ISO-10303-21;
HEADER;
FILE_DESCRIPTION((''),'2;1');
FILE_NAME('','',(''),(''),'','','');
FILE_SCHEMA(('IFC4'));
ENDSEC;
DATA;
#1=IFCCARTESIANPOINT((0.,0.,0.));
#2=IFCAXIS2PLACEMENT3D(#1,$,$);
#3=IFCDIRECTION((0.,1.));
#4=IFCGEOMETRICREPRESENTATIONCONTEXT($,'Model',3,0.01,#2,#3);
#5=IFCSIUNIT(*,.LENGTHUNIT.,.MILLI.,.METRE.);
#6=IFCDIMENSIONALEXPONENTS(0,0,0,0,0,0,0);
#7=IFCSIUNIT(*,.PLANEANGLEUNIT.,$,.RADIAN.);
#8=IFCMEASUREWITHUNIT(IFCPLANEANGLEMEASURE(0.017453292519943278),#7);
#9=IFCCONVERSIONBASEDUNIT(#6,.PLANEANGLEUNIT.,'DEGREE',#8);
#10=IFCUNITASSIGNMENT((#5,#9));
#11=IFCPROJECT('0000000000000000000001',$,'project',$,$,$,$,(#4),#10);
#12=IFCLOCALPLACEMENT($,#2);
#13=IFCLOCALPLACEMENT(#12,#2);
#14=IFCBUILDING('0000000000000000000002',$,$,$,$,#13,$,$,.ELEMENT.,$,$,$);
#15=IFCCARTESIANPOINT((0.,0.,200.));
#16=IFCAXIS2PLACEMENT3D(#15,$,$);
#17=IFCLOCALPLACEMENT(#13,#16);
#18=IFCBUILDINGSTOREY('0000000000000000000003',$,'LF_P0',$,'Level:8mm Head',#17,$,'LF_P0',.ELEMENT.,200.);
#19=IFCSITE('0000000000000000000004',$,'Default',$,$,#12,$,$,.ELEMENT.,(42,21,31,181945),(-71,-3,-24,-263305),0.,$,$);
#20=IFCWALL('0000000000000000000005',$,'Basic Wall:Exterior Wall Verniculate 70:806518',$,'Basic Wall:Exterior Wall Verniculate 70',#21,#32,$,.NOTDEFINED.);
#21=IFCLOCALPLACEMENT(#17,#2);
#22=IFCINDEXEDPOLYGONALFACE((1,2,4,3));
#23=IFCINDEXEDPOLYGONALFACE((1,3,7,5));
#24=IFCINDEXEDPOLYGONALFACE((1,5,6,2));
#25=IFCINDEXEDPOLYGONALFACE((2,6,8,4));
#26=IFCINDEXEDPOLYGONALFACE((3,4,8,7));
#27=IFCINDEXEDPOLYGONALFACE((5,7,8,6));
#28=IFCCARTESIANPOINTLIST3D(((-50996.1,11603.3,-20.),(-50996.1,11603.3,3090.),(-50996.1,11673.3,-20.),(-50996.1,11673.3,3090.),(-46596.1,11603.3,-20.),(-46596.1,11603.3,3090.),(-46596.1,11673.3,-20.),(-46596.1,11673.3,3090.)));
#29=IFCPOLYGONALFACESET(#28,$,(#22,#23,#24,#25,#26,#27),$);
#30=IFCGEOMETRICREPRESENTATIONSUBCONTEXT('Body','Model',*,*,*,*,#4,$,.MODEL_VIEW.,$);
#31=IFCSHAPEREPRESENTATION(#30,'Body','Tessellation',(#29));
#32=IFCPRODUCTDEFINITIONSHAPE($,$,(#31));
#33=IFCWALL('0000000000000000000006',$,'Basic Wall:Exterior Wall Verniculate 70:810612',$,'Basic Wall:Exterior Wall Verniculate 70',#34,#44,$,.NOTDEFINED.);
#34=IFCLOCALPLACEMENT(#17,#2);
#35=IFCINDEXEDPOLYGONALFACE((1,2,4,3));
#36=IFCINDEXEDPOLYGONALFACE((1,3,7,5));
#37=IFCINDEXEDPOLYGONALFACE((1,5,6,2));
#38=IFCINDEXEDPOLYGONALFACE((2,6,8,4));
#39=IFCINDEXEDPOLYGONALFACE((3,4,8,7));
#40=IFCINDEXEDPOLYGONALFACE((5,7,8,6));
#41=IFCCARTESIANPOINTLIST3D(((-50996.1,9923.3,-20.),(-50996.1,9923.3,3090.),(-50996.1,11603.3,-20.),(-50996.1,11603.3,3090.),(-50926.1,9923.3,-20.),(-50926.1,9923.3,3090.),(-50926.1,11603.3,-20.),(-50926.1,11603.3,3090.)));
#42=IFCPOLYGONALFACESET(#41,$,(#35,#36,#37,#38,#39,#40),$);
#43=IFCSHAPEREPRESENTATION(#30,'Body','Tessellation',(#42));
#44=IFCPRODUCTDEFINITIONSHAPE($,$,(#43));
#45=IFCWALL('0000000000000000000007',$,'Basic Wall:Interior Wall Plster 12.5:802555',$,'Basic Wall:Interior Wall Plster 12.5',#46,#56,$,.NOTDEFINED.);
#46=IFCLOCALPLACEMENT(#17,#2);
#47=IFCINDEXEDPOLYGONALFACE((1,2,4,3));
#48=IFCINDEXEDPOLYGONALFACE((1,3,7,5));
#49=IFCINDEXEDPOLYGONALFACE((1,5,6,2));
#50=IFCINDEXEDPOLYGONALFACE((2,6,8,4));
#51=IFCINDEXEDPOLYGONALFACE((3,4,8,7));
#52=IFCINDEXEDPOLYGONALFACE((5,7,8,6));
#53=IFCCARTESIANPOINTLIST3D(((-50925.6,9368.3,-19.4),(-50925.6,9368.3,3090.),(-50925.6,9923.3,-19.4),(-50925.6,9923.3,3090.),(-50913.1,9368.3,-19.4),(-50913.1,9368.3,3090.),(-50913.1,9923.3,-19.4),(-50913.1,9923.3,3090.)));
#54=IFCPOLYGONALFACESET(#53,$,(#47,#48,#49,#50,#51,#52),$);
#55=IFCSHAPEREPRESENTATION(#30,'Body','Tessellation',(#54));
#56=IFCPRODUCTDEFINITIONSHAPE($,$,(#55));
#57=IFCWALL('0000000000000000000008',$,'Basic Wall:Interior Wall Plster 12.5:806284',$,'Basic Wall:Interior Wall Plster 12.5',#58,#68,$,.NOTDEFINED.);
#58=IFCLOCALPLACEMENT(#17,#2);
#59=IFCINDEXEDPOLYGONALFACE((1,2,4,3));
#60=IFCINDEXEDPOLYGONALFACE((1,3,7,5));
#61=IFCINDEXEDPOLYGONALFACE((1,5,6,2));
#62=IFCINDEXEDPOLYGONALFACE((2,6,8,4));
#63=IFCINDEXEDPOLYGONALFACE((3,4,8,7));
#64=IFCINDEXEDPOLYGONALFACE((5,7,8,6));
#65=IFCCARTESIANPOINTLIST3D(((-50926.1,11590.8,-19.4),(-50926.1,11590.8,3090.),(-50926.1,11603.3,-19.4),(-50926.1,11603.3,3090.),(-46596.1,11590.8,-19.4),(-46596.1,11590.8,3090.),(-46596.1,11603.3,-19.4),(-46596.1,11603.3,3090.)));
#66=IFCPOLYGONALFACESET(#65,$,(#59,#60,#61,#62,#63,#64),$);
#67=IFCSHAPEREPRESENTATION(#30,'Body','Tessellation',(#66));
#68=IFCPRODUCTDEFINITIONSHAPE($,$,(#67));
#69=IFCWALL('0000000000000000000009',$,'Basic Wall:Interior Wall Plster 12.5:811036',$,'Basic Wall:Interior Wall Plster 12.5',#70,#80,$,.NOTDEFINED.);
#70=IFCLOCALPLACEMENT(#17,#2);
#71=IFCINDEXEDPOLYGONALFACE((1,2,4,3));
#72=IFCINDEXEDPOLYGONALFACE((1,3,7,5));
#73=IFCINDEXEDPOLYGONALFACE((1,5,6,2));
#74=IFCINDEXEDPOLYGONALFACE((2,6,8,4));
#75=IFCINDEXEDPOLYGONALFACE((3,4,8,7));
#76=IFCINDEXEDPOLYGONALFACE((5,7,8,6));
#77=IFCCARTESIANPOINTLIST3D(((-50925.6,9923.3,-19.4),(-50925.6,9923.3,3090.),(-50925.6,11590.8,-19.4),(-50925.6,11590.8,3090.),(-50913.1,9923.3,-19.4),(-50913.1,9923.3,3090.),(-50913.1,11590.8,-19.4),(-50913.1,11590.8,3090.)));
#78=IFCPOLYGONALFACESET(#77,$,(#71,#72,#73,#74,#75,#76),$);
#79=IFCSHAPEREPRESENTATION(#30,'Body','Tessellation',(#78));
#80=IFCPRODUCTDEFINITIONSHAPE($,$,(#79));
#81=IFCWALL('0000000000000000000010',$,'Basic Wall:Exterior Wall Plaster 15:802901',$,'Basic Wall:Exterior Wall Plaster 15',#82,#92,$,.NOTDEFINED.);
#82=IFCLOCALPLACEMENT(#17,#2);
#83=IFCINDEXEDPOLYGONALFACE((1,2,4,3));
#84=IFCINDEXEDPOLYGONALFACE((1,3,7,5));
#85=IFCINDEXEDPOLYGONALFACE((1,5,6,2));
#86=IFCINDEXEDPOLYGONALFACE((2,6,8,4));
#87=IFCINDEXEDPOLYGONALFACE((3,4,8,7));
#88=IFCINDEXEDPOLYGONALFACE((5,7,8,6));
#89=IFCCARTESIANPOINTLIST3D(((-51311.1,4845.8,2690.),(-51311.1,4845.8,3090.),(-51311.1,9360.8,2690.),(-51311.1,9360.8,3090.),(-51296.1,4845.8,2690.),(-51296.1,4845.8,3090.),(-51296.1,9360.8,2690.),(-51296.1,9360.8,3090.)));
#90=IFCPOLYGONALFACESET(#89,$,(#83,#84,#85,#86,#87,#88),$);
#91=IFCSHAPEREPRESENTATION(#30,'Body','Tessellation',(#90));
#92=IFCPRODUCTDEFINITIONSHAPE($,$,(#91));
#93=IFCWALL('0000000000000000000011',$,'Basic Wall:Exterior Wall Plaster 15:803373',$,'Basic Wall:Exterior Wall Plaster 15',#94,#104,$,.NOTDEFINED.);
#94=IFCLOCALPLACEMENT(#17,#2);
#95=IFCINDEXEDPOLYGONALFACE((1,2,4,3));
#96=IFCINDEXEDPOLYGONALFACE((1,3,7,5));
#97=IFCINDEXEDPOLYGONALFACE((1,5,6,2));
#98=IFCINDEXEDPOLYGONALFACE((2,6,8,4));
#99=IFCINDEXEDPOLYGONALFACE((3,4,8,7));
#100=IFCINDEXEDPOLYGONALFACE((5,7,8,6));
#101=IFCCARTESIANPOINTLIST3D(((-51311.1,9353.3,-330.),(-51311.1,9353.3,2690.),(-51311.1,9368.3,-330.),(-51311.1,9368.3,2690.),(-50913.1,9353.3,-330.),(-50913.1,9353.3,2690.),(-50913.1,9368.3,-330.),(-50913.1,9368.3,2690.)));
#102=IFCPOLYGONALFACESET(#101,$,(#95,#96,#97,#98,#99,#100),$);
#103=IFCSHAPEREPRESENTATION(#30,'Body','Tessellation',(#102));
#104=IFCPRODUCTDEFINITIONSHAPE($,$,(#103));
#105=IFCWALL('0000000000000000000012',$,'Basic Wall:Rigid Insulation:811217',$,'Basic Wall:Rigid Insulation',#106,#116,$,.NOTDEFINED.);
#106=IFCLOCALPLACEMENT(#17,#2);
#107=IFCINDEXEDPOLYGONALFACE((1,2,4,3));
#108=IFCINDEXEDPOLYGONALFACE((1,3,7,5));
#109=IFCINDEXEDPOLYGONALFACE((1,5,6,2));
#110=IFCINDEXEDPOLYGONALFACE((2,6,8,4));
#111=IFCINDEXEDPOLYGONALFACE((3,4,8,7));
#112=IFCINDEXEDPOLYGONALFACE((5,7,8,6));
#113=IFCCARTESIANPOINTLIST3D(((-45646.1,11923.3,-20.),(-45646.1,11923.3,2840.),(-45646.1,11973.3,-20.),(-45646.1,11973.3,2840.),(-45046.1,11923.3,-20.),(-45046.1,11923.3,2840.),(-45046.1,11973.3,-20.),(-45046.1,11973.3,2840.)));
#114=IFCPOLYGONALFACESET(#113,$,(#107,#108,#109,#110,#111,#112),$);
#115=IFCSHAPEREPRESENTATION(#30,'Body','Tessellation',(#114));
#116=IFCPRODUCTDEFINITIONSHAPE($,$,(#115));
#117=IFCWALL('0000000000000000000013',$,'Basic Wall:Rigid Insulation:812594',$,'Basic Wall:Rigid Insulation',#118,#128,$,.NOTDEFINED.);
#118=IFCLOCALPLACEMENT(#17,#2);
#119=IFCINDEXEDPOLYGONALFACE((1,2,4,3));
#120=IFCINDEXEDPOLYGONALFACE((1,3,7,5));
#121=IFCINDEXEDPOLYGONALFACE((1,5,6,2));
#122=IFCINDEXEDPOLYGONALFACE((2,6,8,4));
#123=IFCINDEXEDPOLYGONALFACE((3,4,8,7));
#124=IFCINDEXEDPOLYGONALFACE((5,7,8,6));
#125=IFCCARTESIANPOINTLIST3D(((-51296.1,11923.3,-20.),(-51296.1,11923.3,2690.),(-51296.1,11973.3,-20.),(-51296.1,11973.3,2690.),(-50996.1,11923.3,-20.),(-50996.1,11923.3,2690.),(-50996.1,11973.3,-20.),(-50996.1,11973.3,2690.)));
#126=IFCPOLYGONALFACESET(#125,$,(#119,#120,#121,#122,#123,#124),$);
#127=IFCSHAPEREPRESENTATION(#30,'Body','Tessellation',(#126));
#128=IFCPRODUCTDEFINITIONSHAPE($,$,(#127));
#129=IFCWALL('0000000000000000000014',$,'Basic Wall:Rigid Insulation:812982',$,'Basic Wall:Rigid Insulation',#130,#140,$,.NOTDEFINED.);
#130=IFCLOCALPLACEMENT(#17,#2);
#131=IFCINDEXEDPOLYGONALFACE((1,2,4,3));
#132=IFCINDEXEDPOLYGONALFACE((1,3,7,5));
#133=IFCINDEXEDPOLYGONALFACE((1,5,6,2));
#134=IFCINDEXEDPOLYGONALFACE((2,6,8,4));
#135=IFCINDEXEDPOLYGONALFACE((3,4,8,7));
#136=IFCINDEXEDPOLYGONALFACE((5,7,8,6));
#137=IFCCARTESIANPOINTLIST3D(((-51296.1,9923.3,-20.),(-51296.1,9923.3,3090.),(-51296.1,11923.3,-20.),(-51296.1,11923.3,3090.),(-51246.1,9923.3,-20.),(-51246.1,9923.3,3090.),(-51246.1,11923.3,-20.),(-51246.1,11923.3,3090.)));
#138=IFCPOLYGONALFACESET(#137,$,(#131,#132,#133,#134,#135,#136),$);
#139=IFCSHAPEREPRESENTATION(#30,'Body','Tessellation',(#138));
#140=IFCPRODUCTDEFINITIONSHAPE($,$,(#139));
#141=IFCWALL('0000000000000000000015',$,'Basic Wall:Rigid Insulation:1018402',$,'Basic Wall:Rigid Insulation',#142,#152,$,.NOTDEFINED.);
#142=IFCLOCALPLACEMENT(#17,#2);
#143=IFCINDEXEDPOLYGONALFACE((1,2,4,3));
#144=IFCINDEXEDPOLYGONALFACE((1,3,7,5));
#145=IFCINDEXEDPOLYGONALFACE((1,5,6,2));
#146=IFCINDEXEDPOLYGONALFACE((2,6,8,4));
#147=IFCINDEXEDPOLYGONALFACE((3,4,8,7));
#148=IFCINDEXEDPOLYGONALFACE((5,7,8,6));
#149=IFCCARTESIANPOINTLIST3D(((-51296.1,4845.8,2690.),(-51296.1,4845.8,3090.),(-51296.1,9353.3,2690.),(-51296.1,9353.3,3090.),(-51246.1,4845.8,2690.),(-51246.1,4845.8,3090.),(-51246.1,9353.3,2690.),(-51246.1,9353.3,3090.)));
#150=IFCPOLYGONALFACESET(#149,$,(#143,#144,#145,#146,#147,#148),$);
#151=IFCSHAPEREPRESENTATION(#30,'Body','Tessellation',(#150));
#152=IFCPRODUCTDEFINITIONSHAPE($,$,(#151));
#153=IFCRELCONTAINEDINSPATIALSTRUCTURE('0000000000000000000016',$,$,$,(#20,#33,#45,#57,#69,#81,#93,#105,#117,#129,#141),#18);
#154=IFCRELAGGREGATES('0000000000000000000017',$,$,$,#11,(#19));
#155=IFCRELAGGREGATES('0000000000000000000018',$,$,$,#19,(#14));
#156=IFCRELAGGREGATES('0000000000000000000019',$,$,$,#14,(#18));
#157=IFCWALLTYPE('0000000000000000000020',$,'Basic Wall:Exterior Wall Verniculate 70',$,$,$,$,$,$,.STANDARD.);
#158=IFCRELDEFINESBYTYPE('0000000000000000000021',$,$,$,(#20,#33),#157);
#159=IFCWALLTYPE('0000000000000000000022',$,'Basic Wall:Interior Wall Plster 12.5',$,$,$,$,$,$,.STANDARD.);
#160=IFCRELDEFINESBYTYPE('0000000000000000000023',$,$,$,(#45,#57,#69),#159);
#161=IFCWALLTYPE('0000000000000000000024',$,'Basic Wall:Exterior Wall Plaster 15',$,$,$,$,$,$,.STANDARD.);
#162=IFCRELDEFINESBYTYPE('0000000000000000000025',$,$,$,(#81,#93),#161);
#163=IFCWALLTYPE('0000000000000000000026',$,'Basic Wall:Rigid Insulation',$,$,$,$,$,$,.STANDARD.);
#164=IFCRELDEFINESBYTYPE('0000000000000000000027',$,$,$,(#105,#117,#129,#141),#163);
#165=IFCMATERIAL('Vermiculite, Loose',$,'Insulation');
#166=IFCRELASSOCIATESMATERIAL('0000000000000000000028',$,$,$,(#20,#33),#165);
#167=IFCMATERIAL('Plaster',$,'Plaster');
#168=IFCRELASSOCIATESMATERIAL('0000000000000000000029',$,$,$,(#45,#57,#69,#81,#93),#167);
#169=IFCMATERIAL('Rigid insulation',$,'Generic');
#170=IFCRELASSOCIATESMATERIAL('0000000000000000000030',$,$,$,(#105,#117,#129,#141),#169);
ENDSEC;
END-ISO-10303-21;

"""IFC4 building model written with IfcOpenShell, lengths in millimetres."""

from ifc_helpers import new_model, entity, si_unit, converted_unit, direction, frame, origin, place, context, subcontext, project, spatial, indexed_curve, outline, extrude, material, type_object, element, save


model = new_model("IFC4")

# Units and contexts
model_context = context("Model", 3, precision=0.01, world=origin(), true_north=direction((0.0, 1.0)))
body_context = subcontext(model_context, "Body", "Model", "MODEL_VIEW")
ifc_project = project(units=[si_unit("LENGTHUNIT", "METRE", prefix="MILLI"), converted_unit("PLANEANGLEUNIT", "DEGREE", entity("IfcPlaneAngleMeasure", 0.017453292519943278), si_unit("PLANEANGLEUNIT", "RADIAN"), dimensions=[0, 0, 0, 0, 0, 0, 0])], contexts=[model_context])

# Site, building, storey
site_placement = place(None, origin())
site = spatial("IfcSite", under=ifc_project, at=site_placement, Name="Default", CompositionType="ELEMENT", RefLatitude=(42, 21, 31, 181945), RefLongitude=(-71, -3, -24, -263305), RefElevation=0.0)
building_placement = place(site_placement, origin())
building = spatial("IfcBuilding", under=site, at=building_placement, CompositionType="ELEMENT")
storey_placement = place(building_placement, frame((0.0, 0.0, 200.0)))
storey = spatial("IfcBuildingStorey", under=building, at=storey_placement, Name="LF_P0", ObjectType="Level:8mm Head", LongName="LF_P0", CompositionType="ELEMENT", Elevation=200.0)

# Walls
ifc_material_1 = material(Name="Vermiculite, Loose", Category="Insulation")
wall_type_1 = type_object("IfcWallType", Name="Basic Wall:Exterior Wall Verniculate 70", PredefinedType="STANDARD")
wall_1_placement = place(storey_placement, frame((-50996.1, 11638.3, -20.0)))
element("IfcWall", 1, at=wall_1_placement, inside=storey, type_object=wall_type_1, material=ifc_material_1, Name="Basic Wall:Exterior Wall Verniculate 70:806518", ObjectType="Basic Wall:Exterior Wall Verniculate 70", PredefinedType="NOTDEFINED", context=body_context, shape_type="SweptSolid", body=[
    extrude(outline(indexed_curve([(4400.0, 35.0), (0.0, 35.0), (0.0, -35.0), (4400.0, -35.0), (4400.0, 35.0)], self_intersect=False)), origin(), (0.0, 0.0, 1.0), 3110.0),
])
wall_2_placement = place(storey_placement, frame((-50961.1, 11603.3, -20.0), z_axis=(0.0, 0.0, 1.0), x_axis=(0.0, -1.0, 0.0)))
element("IfcWall", 2, at=wall_2_placement, inside=storey, type_object=wall_type_1, material=ifc_material_1, Name="Basic Wall:Exterior Wall Verniculate 70:810612", ObjectType="Basic Wall:Exterior Wall Verniculate 70", PredefinedType="NOTDEFINED", context=body_context, shape_type="SweptSolid", body=[
    extrude(outline(indexed_curve([(1680.0, 35.0), (0.0, 35.0), (0.0, -35.0), (1680.0, -35.0), (1680.0, 35.0)], self_intersect=False)), origin(), (0.0, 0.0, 1.0), 3110.0),
])
ifc_material_2 = material(Name="Plaster", Category="Plaster")
wall_type_2 = type_object("IfcWallType", Name="Basic Wall:Interior Wall Plster 12.5", PredefinedType="STANDARD")
wall_3_placement = place(storey_placement, frame((-50919.4, 9923.3, -19.4), z_axis=(0.0, 0.0, 1.0), x_axis=(0.0, -1.0, 0.0)))
element("IfcWall", 3, at=wall_3_placement, inside=storey, type_object=wall_type_2, material=ifc_material_2, Name="Basic Wall:Interior Wall Plster 12.5:802555", ObjectType="Basic Wall:Interior Wall Plster 12.5", PredefinedType="NOTDEFINED", context=body_context, shape_type="SweptSolid", body=[
    extrude(outline(indexed_curve([(555.0, 6.3), (0.0, 6.3), (0.0, -6.3), (555.0, -6.3), (555.0, 6.3)], self_intersect=False)), origin(), (0.0, 0.0, 1.0), 3109.4),
])
wall_4_placement = place(storey_placement, frame((-50926.1, 11597.1, -19.4)))
element("IfcWall", 4, at=wall_4_placement, inside=storey, type_object=wall_type_2, material=ifc_material_2, Name="Basic Wall:Interior Wall Plster 12.5:806284", ObjectType="Basic Wall:Interior Wall Plster 12.5", PredefinedType="NOTDEFINED", context=body_context, shape_type="SweptSolid", body=[
    extrude(outline(indexed_curve([(4330.0, 6.2), (0.0, 6.3), (0.0, -6.3), (4330.0, -6.3), (4330.0, 6.2)], self_intersect=False)), origin(), (0.0, 0.0, 1.0), 3109.4),
])
wall_5_placement = place(storey_placement, frame((-50919.4, 11590.8, -19.4), z_axis=(0.0, 0.0, 1.0), x_axis=(0.0, -1.0, 0.0)))
element("IfcWall", 5, at=wall_5_placement, inside=storey, type_object=wall_type_2, material=ifc_material_2, Name="Basic Wall:Interior Wall Plster 12.5:811036", ObjectType="Basic Wall:Interior Wall Plster 12.5", PredefinedType="NOTDEFINED", context=body_context, shape_type="SweptSolid", body=[
    extrude(outline(indexed_curve([(1667.5, 6.3), (0.0, 6.3), (0.0, -6.3), (1667.5, -6.3), (1667.5, 6.3)], self_intersect=False)), origin(), (0.0, 0.0, 1.0), 3109.4),
])
wall_type_3 = type_object("IfcWallType", Name="Basic Wall:Exterior Wall Plaster 15", PredefinedType="STANDARD")
wall_6_placement = place(storey_placement, frame((-51303.6, 9360.8, 2690.0), z_axis=(0.0, 0.0, 1.0), x_axis=(0.0, -1.0, 0.0)))
element("IfcWall", 6, at=wall_6_placement, inside=storey, type_object=wall_type_3, material=ifc_material_2, Name="Basic Wall:Exterior Wall Plaster 15:802901", ObjectType="Basic Wall:Exterior Wall Plaster 15", PredefinedType="NOTDEFINED", context=body_context, shape_type="SweptSolid", body=[
    extrude(outline(indexed_curve([(4515.0, 7.5), (0.0, 7.5), (0.0, -7.5), (4515.0, -7.5), (4515.0, 7.5)], self_intersect=False)), origin(), (0.0, 0.0, 1.0), 400.0),
])
wall_7_placement = place(storey_placement, frame((-50913.1, 9360.8, -330.0), z_axis=(0.0, 0.0, 1.0), x_axis=(-1.0, 0.0, 0.0)))
element("IfcWall", 7, at=wall_7_placement, inside=storey, type_object=wall_type_3, material=ifc_material_2, Name="Basic Wall:Exterior Wall Plaster 15:803373", ObjectType="Basic Wall:Exterior Wall Plaster 15", PredefinedType="NOTDEFINED", context=body_context, shape_type="SweptSolid", body=[
    extrude(outline(indexed_curve([(398.0, 7.5), (0.0, 7.5), (0.0, -7.5), (398.0, -7.5), (398.0, 7.5)], self_intersect=False)), origin(), (0.0, 0.0, 1.0), 3020.0),
])
ifc_material_3 = material(Name="Rigid insulation", Category="Generic")
wall_type_4 = type_object("IfcWallType", Name="Basic Wall:Rigid Insulation", PredefinedType="STANDARD")
wall_8_placement = place(storey_placement, frame((-45646.1, 11948.3, -20.0)))
element("IfcWall", 8, at=wall_8_placement, inside=storey, type_object=wall_type_4, material=ifc_material_3, Name="Basic Wall:Rigid Insulation:811217", ObjectType="Basic Wall:Rigid Insulation", PredefinedType="NOTDEFINED", context=body_context, shape_type="SweptSolid", body=[
    extrude(outline(indexed_curve([(600.0, 25.0), (0.0, 25.0), (0.0, -25.0), (600.0, -25.0), (600.0, 25.0)], self_intersect=False)), origin(), (0.0, 0.0, 1.0), 2860.0),
])
wall_9_placement = place(storey_placement, frame((-50996.1, 11948.3, -20.0), z_axis=(0.0, 0.0, 1.0), x_axis=(-1.0, 0.0, 0.0)))
element("IfcWall", 9, at=wall_9_placement, inside=storey, type_object=wall_type_4, material=ifc_material_3, Name="Basic Wall:Rigid Insulation:812594", ObjectType="Basic Wall:Rigid Insulation", PredefinedType="NOTDEFINED", context=body_context, shape_type="SweptSolid", body=[
    extrude(outline(indexed_curve([(300.0, 25.0), (0.0, 25.0), (0.0, -25.0), (300.0, -25.0), (300.0, 25.0)], self_intersect=False)), origin(), (0.0, 0.0, 1.0), 2710.0),
])
wall_10_placement = place(storey_placement, frame((-51271.1, 11923.3, -20.0), z_axis=(0.0, 0.0, 1.0), x_axis=(0.0, -1.0, 0.0)))
element("IfcWall", 10, at=wall_10_placement, inside=storey, type_object=wall_type_4, material=ifc_material_3, Name="Basic Wall:Rigid Insulation:812982", ObjectType="Basic Wall:Rigid Insulation", PredefinedType="NOTDEFINED", context=body_context, shape_type="SweptSolid", body=[
    extrude(outline(indexed_curve([(2000.0, 25.0), (0.0, 25.0), (0.0, -25.0), (2000.0, -25.0), (2000.0, 25.0)], self_intersect=False)), origin(), (0.0, 0.0, 1.0), 3110.0),
])
wall_11_placement = place(storey_placement, frame((-51271.1, 9353.3, 2690.0), z_axis=(0.0, 0.0, 1.0), x_axis=(0.0, -1.0, 0.0)))
element("IfcWall", 11, at=wall_11_placement, inside=storey, type_object=wall_type_4, material=ifc_material_3, Name="Basic Wall:Rigid Insulation:1018402", ObjectType="Basic Wall:Rigid Insulation", PredefinedType="NOTDEFINED", context=body_context, shape_type="SweptSolid", body=[
    extrude(outline(indexed_curve([(4507.5, 25.0), (0.0, 25.0), (0.0, -25.0), (4507.5, -25.0), (4507.5, 25.0)], self_intersect=False)), origin(), (0.0, 0.0, 1.0), 400.0),
])

save(model, "model.ifc")
